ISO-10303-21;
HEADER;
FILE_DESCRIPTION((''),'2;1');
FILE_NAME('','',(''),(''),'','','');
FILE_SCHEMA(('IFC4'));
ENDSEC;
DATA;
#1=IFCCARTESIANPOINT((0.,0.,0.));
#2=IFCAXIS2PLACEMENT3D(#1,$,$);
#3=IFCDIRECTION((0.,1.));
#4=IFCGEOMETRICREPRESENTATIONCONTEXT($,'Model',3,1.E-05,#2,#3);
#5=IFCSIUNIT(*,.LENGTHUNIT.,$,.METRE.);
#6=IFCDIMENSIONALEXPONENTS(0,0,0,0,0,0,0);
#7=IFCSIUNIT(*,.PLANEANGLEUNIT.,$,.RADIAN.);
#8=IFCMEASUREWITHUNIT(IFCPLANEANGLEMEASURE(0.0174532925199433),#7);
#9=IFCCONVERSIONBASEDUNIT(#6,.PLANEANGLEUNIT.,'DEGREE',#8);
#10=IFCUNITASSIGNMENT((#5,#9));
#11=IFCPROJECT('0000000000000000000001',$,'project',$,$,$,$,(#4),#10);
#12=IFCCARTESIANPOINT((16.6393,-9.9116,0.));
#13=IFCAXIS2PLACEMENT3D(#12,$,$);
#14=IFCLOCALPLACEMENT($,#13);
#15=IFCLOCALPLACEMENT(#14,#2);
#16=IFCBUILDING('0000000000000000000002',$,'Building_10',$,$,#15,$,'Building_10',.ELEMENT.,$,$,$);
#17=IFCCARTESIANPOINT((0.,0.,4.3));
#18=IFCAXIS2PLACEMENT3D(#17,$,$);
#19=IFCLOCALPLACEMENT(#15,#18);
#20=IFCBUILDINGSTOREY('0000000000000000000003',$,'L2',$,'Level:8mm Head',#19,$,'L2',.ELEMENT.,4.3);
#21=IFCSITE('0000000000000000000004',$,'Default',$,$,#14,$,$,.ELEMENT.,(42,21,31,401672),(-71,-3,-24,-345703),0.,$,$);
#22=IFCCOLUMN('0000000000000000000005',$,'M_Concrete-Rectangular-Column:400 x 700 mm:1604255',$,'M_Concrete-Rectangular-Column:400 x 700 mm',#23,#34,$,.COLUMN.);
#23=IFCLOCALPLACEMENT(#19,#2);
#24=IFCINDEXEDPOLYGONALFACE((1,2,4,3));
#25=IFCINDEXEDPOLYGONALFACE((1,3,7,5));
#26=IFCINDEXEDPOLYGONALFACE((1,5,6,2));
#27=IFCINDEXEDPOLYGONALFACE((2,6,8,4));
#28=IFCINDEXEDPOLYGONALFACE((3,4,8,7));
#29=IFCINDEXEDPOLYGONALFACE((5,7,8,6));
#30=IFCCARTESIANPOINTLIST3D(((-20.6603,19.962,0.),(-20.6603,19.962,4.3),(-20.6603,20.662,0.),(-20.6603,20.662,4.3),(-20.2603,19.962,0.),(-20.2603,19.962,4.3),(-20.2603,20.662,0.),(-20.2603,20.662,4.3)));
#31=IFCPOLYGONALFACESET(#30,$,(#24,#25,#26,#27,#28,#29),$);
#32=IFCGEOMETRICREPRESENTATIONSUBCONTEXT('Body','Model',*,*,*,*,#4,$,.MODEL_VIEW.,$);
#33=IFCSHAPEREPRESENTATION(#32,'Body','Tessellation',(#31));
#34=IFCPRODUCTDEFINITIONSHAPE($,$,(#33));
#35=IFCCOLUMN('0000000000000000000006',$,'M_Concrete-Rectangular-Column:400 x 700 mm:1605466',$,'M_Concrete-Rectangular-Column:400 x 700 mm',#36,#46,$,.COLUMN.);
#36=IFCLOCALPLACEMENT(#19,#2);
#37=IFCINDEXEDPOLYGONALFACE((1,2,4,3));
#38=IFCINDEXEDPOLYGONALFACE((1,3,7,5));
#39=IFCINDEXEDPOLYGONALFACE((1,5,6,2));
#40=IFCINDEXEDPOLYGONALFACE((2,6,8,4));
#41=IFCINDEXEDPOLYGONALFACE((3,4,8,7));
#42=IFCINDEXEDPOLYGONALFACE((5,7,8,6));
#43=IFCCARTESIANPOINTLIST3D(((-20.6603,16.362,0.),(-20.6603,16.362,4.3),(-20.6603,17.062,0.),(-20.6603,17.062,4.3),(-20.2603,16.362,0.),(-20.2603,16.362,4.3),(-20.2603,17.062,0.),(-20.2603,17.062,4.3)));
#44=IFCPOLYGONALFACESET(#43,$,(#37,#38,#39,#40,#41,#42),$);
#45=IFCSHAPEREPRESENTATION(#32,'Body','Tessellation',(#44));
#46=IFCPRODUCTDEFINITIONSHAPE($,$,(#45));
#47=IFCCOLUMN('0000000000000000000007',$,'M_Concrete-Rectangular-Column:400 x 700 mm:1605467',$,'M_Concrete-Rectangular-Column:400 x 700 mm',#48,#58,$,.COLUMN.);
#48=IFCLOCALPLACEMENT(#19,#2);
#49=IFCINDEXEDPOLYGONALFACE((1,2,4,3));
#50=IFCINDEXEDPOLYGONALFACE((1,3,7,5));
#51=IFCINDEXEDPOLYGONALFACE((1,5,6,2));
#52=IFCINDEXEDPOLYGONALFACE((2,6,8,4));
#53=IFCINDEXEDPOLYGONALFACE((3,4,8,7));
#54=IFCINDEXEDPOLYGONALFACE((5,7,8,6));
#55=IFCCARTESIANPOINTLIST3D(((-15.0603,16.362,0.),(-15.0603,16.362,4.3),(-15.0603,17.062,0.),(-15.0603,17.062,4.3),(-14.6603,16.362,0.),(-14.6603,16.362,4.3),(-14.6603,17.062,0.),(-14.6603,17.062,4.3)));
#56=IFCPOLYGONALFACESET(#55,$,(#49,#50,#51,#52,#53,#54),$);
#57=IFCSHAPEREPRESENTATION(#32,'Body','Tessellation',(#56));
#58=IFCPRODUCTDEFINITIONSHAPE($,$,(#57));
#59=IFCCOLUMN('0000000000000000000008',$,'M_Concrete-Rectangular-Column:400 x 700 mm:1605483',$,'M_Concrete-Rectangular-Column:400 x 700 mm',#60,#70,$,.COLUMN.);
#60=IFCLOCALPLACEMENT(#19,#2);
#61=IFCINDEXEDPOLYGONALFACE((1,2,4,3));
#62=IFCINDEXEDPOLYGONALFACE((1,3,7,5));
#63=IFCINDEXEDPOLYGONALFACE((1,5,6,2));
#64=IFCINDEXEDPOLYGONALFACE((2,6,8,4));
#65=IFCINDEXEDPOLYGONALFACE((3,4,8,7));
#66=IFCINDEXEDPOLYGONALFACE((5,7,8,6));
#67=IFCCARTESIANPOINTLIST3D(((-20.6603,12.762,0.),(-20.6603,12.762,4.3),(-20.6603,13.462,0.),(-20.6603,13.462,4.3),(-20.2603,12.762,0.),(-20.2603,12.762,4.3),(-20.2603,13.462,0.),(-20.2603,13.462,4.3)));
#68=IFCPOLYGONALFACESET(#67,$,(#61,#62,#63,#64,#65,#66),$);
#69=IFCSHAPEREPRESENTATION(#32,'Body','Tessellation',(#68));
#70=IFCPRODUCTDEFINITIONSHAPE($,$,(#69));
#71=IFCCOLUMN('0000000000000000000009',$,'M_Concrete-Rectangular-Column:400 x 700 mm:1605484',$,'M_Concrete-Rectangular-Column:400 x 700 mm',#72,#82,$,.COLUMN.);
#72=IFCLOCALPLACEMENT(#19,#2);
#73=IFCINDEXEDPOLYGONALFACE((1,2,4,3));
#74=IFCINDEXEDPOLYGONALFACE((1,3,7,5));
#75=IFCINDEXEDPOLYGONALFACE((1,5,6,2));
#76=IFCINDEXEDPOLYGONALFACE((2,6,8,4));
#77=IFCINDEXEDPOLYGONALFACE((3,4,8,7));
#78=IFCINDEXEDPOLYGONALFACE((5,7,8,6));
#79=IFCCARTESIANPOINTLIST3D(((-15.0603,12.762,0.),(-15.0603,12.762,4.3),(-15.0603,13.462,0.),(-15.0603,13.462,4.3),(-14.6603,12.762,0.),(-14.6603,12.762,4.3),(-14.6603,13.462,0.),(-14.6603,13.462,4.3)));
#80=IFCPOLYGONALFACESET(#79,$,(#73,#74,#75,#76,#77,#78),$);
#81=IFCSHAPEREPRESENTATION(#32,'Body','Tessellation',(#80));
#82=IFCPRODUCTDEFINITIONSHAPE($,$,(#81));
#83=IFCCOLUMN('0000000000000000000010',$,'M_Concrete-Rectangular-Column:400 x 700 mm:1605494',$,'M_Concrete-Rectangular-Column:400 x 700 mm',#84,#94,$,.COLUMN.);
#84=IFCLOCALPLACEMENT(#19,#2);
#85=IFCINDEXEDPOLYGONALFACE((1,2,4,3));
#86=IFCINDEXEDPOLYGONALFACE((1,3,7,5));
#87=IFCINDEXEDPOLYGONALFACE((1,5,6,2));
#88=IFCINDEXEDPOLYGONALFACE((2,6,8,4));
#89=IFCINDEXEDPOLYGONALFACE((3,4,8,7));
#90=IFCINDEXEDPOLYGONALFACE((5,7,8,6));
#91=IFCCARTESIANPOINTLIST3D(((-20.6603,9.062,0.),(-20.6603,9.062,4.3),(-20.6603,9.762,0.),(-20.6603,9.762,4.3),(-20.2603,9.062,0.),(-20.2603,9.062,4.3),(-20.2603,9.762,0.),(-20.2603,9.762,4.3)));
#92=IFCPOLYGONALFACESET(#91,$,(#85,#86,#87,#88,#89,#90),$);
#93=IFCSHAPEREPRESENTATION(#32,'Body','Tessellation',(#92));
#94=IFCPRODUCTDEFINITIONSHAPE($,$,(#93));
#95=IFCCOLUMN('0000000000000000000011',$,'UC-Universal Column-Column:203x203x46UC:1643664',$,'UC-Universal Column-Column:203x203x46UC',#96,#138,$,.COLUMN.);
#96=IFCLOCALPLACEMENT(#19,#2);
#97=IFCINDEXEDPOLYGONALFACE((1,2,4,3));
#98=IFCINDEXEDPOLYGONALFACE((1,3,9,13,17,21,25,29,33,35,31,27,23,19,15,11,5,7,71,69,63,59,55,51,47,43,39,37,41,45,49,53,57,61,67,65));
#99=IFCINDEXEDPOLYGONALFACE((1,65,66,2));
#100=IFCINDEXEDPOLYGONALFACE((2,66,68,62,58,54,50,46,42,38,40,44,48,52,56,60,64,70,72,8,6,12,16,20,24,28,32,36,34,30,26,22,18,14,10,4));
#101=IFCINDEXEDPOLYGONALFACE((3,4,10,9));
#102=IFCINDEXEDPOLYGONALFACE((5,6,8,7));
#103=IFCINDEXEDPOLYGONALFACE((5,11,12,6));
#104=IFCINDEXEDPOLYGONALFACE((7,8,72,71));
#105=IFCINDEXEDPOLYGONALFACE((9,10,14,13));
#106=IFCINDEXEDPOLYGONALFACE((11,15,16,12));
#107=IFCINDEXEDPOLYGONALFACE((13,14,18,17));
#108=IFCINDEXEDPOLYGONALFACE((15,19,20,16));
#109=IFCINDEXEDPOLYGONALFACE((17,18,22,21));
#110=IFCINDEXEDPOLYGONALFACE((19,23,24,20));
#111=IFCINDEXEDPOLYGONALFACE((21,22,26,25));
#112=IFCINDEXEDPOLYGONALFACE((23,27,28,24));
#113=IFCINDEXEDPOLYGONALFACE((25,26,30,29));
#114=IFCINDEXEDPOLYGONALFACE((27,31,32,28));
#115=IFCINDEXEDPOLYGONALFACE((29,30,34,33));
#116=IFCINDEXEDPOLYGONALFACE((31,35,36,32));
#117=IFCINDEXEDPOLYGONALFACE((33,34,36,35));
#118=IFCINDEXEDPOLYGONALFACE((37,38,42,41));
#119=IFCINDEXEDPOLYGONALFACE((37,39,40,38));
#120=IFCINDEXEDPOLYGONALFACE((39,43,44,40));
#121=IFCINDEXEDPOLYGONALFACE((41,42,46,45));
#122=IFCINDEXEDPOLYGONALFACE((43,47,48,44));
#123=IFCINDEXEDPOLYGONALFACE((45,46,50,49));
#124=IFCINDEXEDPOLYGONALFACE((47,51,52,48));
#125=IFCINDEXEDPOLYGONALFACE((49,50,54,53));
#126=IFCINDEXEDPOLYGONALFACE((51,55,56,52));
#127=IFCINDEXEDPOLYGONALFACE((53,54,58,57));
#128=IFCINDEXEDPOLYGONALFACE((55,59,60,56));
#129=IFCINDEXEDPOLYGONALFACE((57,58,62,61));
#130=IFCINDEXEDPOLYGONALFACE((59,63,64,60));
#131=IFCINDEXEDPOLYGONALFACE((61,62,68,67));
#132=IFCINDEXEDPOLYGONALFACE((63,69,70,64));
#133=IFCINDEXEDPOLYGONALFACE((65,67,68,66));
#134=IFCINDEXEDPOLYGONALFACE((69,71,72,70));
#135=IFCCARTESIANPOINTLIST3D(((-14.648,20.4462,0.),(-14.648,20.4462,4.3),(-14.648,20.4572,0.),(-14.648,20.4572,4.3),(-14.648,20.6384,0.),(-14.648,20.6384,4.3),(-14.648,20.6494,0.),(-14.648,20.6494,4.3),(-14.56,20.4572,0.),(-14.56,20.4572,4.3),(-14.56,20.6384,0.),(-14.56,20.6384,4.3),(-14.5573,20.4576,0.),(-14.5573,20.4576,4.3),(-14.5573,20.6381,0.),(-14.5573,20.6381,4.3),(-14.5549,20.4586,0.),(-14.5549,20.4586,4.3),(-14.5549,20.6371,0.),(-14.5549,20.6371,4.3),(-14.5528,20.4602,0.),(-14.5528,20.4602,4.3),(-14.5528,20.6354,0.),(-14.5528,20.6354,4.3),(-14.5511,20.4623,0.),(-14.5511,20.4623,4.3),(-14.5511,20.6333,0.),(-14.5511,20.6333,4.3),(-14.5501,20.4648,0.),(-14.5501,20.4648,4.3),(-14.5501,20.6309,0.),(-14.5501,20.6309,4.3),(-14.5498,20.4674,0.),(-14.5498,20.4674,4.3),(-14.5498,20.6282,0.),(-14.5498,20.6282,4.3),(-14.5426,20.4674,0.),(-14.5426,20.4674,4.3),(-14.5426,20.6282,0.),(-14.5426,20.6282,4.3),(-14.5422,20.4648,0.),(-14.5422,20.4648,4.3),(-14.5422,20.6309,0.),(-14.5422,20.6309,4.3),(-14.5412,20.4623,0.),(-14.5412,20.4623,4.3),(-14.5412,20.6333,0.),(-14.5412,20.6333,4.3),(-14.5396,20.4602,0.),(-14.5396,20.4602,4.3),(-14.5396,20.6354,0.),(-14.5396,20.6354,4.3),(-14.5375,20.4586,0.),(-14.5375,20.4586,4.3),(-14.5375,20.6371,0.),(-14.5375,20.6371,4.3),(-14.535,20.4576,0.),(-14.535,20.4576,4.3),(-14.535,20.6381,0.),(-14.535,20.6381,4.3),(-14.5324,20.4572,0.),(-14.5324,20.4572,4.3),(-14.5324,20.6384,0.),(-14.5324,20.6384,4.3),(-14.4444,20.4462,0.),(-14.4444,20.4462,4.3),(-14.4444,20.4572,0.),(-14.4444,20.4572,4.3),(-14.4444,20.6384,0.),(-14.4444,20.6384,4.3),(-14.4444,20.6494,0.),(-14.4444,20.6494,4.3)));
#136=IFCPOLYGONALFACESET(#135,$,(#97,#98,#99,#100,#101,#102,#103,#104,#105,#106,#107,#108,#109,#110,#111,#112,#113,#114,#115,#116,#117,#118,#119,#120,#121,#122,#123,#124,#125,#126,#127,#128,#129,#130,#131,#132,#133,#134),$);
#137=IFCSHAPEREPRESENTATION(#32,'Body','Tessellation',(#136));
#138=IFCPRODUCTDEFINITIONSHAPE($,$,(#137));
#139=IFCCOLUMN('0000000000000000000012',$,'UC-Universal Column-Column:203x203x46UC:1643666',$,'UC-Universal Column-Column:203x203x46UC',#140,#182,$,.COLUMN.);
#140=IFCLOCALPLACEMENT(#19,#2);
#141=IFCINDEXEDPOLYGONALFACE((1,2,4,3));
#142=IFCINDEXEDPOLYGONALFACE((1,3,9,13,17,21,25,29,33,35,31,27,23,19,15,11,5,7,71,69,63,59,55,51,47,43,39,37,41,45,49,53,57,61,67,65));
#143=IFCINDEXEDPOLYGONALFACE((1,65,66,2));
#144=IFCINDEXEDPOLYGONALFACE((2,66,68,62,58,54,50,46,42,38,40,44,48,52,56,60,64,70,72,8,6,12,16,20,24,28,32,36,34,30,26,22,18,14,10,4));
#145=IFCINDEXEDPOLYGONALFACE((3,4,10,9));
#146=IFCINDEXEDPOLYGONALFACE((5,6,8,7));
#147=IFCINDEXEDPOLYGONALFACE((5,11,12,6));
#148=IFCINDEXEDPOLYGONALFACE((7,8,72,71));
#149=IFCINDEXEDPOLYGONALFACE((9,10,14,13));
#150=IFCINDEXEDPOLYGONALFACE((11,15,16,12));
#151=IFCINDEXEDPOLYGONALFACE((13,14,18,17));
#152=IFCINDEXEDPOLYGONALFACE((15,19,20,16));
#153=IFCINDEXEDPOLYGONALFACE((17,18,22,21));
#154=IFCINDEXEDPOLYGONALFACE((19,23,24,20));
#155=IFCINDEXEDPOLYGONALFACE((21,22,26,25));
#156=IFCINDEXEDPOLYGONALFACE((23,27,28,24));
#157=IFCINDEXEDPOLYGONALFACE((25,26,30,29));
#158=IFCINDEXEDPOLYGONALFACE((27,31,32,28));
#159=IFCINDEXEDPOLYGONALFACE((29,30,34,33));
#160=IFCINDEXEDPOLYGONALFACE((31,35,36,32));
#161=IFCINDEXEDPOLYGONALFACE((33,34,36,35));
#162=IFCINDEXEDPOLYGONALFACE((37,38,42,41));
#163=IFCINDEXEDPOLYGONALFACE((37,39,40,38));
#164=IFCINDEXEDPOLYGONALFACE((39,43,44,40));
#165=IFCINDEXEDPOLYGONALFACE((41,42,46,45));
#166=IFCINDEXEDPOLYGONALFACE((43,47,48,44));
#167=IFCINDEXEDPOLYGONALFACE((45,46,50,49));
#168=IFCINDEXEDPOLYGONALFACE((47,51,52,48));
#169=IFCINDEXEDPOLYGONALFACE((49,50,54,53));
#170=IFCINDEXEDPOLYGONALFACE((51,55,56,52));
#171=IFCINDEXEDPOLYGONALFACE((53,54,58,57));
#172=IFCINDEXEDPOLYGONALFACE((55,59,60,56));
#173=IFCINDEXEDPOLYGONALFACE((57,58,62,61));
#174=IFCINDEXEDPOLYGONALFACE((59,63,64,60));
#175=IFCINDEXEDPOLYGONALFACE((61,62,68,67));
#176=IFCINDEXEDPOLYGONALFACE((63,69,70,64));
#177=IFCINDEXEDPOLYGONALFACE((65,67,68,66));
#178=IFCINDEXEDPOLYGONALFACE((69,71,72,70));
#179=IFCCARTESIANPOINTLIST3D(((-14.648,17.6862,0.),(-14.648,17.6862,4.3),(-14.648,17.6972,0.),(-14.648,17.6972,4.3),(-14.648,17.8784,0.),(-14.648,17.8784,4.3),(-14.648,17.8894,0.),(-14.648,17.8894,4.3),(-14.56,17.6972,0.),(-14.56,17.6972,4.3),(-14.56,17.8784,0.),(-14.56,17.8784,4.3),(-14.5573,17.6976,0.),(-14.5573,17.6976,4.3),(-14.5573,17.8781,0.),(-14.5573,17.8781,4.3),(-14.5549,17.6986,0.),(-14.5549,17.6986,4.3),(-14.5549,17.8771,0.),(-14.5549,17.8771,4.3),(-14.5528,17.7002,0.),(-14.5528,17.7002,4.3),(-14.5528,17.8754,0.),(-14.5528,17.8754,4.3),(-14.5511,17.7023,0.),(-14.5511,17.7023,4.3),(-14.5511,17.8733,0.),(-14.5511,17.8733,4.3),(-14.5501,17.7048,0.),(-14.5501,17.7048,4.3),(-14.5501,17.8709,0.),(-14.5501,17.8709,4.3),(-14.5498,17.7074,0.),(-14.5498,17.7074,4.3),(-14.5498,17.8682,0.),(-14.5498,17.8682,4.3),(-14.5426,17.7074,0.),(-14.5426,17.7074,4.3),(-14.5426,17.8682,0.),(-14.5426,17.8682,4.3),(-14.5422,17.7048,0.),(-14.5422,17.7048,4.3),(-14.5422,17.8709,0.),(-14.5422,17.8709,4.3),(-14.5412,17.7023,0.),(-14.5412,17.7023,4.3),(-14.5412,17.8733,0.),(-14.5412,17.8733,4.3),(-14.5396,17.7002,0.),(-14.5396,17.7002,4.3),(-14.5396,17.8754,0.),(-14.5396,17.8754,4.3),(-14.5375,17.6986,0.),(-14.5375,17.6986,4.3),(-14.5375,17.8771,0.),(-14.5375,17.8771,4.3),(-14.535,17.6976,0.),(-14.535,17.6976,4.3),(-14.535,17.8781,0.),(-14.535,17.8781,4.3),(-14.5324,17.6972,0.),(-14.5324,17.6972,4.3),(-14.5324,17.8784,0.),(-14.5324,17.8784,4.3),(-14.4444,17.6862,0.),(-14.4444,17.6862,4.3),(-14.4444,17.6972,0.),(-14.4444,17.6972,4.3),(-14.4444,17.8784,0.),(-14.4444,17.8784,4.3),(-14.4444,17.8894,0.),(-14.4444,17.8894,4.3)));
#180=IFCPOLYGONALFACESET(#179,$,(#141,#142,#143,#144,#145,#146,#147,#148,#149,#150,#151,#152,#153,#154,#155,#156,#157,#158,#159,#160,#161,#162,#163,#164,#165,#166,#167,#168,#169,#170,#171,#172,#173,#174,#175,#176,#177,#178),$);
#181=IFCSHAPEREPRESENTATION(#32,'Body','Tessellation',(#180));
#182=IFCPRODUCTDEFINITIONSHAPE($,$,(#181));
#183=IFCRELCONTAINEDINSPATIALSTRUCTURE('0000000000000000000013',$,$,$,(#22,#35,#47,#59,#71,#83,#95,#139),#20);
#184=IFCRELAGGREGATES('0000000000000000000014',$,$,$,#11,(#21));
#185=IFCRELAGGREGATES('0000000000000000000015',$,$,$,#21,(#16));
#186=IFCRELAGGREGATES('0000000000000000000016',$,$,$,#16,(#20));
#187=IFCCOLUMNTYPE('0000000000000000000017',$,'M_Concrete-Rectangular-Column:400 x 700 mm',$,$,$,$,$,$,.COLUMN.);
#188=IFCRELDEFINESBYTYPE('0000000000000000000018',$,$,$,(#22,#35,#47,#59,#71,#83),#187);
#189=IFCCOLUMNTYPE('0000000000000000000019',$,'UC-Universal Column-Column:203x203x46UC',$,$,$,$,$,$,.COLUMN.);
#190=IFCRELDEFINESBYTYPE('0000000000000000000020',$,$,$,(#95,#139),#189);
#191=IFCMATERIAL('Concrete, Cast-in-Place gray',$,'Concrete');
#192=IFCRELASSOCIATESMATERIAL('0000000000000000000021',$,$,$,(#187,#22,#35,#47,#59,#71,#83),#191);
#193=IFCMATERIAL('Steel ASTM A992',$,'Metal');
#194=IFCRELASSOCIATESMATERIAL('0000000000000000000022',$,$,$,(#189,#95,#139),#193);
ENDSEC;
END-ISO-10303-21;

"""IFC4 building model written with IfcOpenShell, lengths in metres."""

from ifc_helpers import new_model, entity, si_unit, converted_unit, direction, frame, origin, place, context, subcontext, project, spatial, line, arc, indexed_curve, outline, extrude, source, transform, mapped, material, type_object, type_shapes, element, save


model = new_model("IFC4")

# Units and contexts
model_context = context("Model", 3, precision=1e-05, world=origin(), true_north=direction((0.0, 1.0)))
body_context = subcontext(model_context, "Body", "Model", "MODEL_VIEW")
ifc_project = project(units=[si_unit("LENGTHUNIT", "METRE"), converted_unit("PLANEANGLEUNIT", "DEGREE", entity("IfcPlaneAngleMeasure", 0.0174532925199433), si_unit("PLANEANGLEUNIT", "RADIAN"), dimensions=[0, 0, 0, 0, 0, 0, 0])], contexts=[model_context])

# Site, building, storey
site_placement = place(None, frame((16.6393, -9.9116, 0.0)))
site = spatial("IfcSite", under=ifc_project, at=site_placement, Name="Default", CompositionType="ELEMENT", RefLatitude=(42, 21, 31, 401672), RefLongitude=(-71, -3, -24, -345703), RefElevation=0.0)
building_placement = place(site_placement, origin())
building = spatial("IfcBuilding", under=site, at=building_placement, Name="Building_10", LongName="Building_10", CompositionType="ELEMENT")
storey_placement = place(building_placement, frame((0.0, 0.0, 4.3)))
storey = spatial("IfcBuildingStorey", under=building, at=storey_placement, Name="L2", ObjectType="Level:8mm Head", LongName="L2", CompositionType="ELEMENT", Elevation=4.3)

# Columns
ifc_material_1 = material(Name="Concrete, Cast-in-Place gray", Category="Concrete")
column_type_1 = type_object("IfcColumnType", Name="M_Concrete-Rectangular-Column:400 x 700 mm", PredefinedType="COLUMN", material=ifc_material_1)
shared_shape_1 = source(origin(), body_context, "Body", "SweptSolid", [
    extrude(outline(indexed_curve([(-0.2, -0.35), (0.2, -0.35), (0.2, 0.35), (-0.2, 0.35), (-0.2, -0.35)], self_intersect=False)), frame((0.0, 0.0, 4.3), z_axis=(0.0, 0.0, 1.0), x_axis=(-1.0, 0.0, 0.0)), (0.0, 0.0, 1.0), 4.3),
])
type_shapes(column_type_1, [shared_shape_1])
for number, where, name in (
    (1, (-20.4603, 20.312, -4.3), "M_Concrete-Rectangular-Column:400 x 700 mm:1604255"),
    (2, (-20.4603, 16.712, -4.3), "M_Concrete-Rectangular-Column:400 x 700 mm:1605466"),
    (3, (-14.8603, 16.712, -4.3), "M_Concrete-Rectangular-Column:400 x 700 mm:1605467"),
    (4, (-20.4603, 13.112, -4.3), "M_Concrete-Rectangular-Column:400 x 700 mm:1605483"),
    (5, (-14.8603, 13.112, -4.3), "M_Concrete-Rectangular-Column:400 x 700 mm:1605484"),
    (6, (-20.4603, 9.412, -4.3), "M_Concrete-Rectangular-Column:400 x 700 mm:1605494"),
):
    element("IfcColumn", number, at=place(storey_placement, frame(where)), inside=storey, type_object=column_type_1, material=ifc_material_1, Name=name, ObjectType="M_Concrete-Rectangular-Column:400 x 700 mm", PredefinedType="COLUMN", context=body_context, shape_type="MappedRepresentation", body=[
        mapped(shared_shape_1, transform((0.0, 0.0, 0.0), scale=1.0)),
    ])
ifc_material_2 = material(Name="Steel ASTM A992", Category="Metal")
column_type_2 = type_object("IfcColumnType", Name="UC-Universal Column-Column:203x203x46UC", PredefinedType="COLUMN", material=ifc_material_2)
shared_shape_2 = source(origin(), body_context, "Body", "SweptSolid", [
    extrude(outline(indexed_curve([(-0.1018, -0.1016), (0.1018, -0.1016), (0.1018, -0.0906), (0.0138, -0.0906), (0.0066, -0.0876), (0.0036, -0.0804), (0.0036, 0.0804), (0.0066, 0.0876), (0.0138, 0.0906), (0.1018, 0.0906), (0.1018, 0.1016), (-0.1018, 0.1016), (-0.1018, 0.0906), (-0.0138, 0.0906), (-0.0066, 0.0876), (-0.0036, 0.0804), (-0.0036, -0.0804), (-0.0066, -0.0876), (-0.0138, -0.0906), (-0.1018, -0.0906)], segments=[line(1, 2, 3, 4), arc(4, 5, 6), line(6, 7), arc(7, 8, 9), line(9, 10, 11, 12, 13, 14), arc(14, 15, 16), line(16, 17), arc(17, 18, 19), line(19, 20, 1)], self_intersect=False)), frame((0.0, 0.0, 4.3), z_axis=(0.0, 0.0, 1.0), x_axis=(-1.0, 0.0, 0.0)), (0.0, 0.0, 1.0), 4.3),
])
type_shapes(column_type_2, [shared_shape_2])
for number, where, name in (
    (7, (-14.5462, 20.5478, -4.3), "UC-Universal Column-Column:203x203x46UC:1643664"),
    (8, (-14.5462, 17.7878, -4.3), "UC-Universal Column-Column:203x203x46UC:1643666"),
):
    element("IfcColumn", number, at=place(storey_placement, frame(where)), inside=storey, type_object=column_type_2, material=ifc_material_2, Name=name, ObjectType="UC-Universal Column-Column:203x203x46UC", PredefinedType="COLUMN", context=body_context, shape_type="MappedRepresentation", body=[
        mapped(shared_shape_2, transform((0.0, 0.0, 0.0), scale=1.0)),
    ])

save(model, "model.ifc")
